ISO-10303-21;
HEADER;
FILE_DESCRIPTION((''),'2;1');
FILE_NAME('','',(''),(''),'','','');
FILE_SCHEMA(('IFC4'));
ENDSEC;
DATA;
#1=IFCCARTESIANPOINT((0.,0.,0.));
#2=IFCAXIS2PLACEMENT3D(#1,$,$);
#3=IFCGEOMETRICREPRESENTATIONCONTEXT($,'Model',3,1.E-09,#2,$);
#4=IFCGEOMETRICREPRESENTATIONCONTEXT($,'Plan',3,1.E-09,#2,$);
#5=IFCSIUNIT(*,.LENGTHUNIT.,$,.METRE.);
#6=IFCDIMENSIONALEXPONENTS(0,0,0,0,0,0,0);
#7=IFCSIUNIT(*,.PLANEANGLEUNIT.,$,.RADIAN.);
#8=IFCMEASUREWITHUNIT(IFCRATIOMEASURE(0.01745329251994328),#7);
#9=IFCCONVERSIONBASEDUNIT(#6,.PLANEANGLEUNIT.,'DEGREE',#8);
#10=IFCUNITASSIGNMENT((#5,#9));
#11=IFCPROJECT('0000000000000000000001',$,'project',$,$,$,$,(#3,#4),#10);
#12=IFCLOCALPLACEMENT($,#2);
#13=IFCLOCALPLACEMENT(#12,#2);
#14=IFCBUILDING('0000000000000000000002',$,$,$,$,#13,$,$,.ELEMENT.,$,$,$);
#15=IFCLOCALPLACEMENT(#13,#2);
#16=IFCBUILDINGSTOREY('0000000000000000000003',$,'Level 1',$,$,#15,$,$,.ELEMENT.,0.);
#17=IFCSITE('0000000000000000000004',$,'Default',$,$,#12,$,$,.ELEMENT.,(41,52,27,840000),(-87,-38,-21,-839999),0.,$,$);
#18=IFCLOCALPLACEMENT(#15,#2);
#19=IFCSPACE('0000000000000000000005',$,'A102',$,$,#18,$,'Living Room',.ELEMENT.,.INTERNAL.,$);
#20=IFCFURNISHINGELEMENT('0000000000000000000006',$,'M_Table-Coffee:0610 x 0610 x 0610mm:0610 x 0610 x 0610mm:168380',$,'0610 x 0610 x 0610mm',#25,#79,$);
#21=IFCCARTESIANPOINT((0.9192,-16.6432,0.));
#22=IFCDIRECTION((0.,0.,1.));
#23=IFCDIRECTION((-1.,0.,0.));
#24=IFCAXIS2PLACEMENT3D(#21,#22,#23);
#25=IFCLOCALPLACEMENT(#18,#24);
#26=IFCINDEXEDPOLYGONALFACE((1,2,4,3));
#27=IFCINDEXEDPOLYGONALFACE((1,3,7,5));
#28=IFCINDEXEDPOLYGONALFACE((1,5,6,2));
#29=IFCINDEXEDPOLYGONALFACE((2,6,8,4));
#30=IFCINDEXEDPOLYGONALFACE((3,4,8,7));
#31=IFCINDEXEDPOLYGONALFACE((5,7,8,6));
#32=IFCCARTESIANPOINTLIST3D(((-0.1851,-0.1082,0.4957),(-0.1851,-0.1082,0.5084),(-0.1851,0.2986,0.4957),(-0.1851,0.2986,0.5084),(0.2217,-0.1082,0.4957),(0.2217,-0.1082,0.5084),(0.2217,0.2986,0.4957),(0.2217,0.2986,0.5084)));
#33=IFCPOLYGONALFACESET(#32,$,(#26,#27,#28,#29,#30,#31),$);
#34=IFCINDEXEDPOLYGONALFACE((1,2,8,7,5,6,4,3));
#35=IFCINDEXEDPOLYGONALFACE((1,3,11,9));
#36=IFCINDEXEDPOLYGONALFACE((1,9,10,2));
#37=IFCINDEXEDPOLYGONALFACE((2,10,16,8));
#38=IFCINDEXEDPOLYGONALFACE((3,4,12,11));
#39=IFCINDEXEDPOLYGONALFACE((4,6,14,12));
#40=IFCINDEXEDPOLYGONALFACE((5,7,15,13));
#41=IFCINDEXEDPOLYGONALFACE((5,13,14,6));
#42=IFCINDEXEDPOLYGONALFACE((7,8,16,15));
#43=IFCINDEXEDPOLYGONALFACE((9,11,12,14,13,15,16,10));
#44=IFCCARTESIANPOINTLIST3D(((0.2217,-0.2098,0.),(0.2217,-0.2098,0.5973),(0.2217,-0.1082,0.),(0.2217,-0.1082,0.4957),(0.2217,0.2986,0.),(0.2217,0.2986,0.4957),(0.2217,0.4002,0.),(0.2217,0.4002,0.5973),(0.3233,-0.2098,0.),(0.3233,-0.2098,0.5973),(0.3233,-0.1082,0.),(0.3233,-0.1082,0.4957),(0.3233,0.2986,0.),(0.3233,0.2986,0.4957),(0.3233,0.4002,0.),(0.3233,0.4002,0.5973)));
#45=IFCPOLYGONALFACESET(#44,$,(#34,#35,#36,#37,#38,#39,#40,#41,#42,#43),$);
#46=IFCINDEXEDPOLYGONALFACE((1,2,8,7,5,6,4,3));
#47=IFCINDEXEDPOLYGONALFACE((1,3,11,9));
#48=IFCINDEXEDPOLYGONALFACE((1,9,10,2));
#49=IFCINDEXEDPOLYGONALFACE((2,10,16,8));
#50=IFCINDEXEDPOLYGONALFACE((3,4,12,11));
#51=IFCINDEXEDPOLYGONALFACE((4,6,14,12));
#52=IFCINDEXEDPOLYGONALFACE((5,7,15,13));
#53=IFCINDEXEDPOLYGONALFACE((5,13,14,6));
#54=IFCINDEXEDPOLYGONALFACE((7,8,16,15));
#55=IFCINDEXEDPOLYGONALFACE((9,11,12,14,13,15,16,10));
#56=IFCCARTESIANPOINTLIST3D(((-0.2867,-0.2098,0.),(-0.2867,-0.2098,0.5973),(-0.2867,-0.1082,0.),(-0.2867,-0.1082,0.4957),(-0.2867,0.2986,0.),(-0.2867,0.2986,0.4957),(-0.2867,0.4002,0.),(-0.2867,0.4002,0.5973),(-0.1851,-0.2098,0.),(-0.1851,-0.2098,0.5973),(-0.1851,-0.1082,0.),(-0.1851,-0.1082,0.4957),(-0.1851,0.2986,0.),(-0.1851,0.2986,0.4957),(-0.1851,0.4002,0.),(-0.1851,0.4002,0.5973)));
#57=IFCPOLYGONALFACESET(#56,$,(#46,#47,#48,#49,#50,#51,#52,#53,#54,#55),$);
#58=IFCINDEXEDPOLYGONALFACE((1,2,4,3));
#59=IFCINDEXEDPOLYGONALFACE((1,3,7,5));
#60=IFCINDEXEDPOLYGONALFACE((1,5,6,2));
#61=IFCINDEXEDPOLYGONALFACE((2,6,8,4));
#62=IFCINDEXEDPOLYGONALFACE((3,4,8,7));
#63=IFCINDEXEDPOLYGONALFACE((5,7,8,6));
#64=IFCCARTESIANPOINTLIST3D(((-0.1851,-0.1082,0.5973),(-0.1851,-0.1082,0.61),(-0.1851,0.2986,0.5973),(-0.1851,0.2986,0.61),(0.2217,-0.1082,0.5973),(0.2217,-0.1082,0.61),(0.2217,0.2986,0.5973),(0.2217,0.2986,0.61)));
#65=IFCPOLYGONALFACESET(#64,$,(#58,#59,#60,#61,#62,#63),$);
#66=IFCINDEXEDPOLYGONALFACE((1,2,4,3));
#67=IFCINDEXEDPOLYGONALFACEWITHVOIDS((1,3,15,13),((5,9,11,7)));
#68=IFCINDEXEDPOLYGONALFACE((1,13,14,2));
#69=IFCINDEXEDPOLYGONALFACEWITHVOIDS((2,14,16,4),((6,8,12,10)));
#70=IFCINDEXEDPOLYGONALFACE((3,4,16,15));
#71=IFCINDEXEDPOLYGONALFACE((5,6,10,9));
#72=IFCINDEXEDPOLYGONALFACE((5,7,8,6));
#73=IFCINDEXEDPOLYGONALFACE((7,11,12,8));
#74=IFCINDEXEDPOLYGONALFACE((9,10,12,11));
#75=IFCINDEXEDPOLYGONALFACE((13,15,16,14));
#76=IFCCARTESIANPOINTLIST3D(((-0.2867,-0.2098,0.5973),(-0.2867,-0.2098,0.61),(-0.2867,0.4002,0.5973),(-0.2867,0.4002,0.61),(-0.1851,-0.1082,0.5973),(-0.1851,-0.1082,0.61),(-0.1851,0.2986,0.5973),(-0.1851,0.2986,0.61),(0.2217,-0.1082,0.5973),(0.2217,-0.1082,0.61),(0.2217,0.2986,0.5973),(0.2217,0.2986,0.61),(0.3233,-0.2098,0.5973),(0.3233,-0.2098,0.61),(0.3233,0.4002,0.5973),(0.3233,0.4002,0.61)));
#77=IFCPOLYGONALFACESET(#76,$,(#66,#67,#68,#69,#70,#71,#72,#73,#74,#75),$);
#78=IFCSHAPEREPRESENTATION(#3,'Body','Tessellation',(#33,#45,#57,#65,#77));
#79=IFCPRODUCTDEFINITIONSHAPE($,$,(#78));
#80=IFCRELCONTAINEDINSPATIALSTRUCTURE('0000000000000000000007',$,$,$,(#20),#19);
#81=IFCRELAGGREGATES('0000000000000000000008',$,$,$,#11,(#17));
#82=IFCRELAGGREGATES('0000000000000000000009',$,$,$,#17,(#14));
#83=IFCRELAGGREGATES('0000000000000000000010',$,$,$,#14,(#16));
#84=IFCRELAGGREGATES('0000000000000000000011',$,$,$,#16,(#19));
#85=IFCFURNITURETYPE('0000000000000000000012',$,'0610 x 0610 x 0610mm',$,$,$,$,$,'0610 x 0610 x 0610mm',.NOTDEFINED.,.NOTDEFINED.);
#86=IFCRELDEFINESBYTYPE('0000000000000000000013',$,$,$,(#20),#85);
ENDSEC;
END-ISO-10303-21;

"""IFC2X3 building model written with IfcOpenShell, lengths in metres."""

from ifc_helpers import new_model, entity, si_unit, converted_unit, frame, origin, origin_2d_with_axis, place, context, project, spatial, polyline, rectangle, outline, extrude, source, transform, mapped, type_object, type_shapes, element, save


model = new_model("IFC2X3")

# Units and contexts
model_context = context("Model", 3, precision=1e-09, world=origin())
plan_context = context("Plan", 3, precision=1e-09, world=origin())
ifc_project = project(units=[si_unit("LENGTHUNIT", "METRE"), converted_unit("PLANEANGLEUNIT", "DEGREE", entity("IfcRatioMeasure", 0.01745329251994328), si_unit("PLANEANGLEUNIT", "RADIAN"), dimensions=[0, 0, 0, 0, 0, 0, 0])], contexts=[model_context, plan_context])

# Site, building, storey
site_placement = place(None, origin())
site = spatial("IfcSite", under=ifc_project, at=site_placement, Name="Default", CompositionType="ELEMENT", RefLatitude=(41, 52, 27, 840000), RefLongitude=(-87, -38, -21, -839999), RefElevation=0.0)
building_placement = place(site_placement, origin())
building = spatial("IfcBuilding", under=site, at=building_placement, CompositionType="ELEMENT")
storey_placement = place(building_placement, origin())
storey = spatial("IfcBuildingStorey", under=building, at=storey_placement, Name="Level 1", CompositionType="ELEMENT", Elevation=0.0)

# Shared definitions
space_placement = place(storey_placement, origin())
space = spatial("IfcSpace", under=storey, at=space_placement, Name="A102", LongName="Living Room", CompositionType="ELEMENT", InteriorOrExteriorSpace="INTERNAL")

# Furnishing element
furniture_type = type_object("IfcFurnitureType", Name="0610 x 0610 x 0610mm", ElementType="0610 x 0610 x 0610mm", AssemblyPlace="NOTDEFINED")
shared_shape_1 = source(origin(), model_context, "Body", "SweptSolid", [
    extrude(rectangle(XDim=0.4068, YDim=0.4068, at=origin_2d_with_axis()), frame((0.0183, 0.0952, 0.4957), z_axis=(0.0, 0.0, 1.0), x_axis=(-1.0, 0.0, 0.0)), (0.0, 0.0, 1.0), 0.0127),
    extrude(outline(polyline([(-0.2732, -0.305), (0.324, -0.305), (0.324, 0.305), (-0.2732, 0.305), (-0.2732, 0.2034), (0.2225, 0.2034), (0.2225, -0.2034), (-0.2732, -0.2034), (-0.2732, -0.305)])), frame((0.2217, 0.0952, 0.2732), z_axis=(1.0, 0.0, 0.0), x_axis=(0.0, 0.0, 1.0)), (0.0, 0.0, 1.0), 0.1016),
    extrude(outline(polyline([(-0.305, -0.3241), (0.305, -0.3241), (0.305, 0.2733), (0.2034, 0.2733), (0.2034, -0.2224), (-0.2034, -0.2224), (-0.2034, 0.2733), (-0.305, 0.2733), (-0.305, -0.3241)])), frame((-0.2867, 0.0952, 0.2733), z_axis=(1.0, 0.0, 0.0), x_axis=(0.0, -1.0, 0.0)), (0.0, 0.0, 1.0), 0.1016),
    extrude(rectangle(XDim=0.4068, YDim=0.4068, at=origin_2d_with_axis()), frame((0.0183, 0.0952, 0.5973), z_axis=(0.0, 0.0, 1.0), x_axis=(-1.0, 0.0, 0.0)), (0.0, 0.0, 1.0), 0.0127),
    extrude(outline(polyline([(-0.305, -0.305), (0.305, -0.305), (0.305, 0.305), (-0.305, 0.305), (-0.305, -0.305)]), holes=[polyline([(-0.2034, -0.2034), (-0.2034, 0.2034), (0.2034, 0.2034), (0.2034, -0.2034), (-0.2034, -0.2034)])]), frame((0.0183, 0.0952, 0.5973), z_axis=(0.0, 0.0, 1.0), x_axis=(-1.0, 0.0, 0.0)), (0.0, 0.0, 1.0), 0.0127),
])
type_shapes(furniture_type, [shared_shape_1])
furnishing_placement = place(space_placement, frame((0.9192, -16.6432, 0.0), z_axis=(0.0, 0.0, 1.0), x_axis=(-1.0, 0.0, 0.0)))
element("IfcFurnishingElement", 1, at=furnishing_placement, inside=space, type_object=furniture_type, Name="M_Table-Coffee:0610 x 0610 x 0610mm:0610 x 0610 x 0610mm:168380", ObjectType="0610 x 0610 x 0610mm", context=model_context, shape_type="MappedRepresentation", body=[
    mapped(shared_shape_1, transform((0.0, 0.0, 0.0), scale=1.0)),
])

save(model, "model.ifc")
